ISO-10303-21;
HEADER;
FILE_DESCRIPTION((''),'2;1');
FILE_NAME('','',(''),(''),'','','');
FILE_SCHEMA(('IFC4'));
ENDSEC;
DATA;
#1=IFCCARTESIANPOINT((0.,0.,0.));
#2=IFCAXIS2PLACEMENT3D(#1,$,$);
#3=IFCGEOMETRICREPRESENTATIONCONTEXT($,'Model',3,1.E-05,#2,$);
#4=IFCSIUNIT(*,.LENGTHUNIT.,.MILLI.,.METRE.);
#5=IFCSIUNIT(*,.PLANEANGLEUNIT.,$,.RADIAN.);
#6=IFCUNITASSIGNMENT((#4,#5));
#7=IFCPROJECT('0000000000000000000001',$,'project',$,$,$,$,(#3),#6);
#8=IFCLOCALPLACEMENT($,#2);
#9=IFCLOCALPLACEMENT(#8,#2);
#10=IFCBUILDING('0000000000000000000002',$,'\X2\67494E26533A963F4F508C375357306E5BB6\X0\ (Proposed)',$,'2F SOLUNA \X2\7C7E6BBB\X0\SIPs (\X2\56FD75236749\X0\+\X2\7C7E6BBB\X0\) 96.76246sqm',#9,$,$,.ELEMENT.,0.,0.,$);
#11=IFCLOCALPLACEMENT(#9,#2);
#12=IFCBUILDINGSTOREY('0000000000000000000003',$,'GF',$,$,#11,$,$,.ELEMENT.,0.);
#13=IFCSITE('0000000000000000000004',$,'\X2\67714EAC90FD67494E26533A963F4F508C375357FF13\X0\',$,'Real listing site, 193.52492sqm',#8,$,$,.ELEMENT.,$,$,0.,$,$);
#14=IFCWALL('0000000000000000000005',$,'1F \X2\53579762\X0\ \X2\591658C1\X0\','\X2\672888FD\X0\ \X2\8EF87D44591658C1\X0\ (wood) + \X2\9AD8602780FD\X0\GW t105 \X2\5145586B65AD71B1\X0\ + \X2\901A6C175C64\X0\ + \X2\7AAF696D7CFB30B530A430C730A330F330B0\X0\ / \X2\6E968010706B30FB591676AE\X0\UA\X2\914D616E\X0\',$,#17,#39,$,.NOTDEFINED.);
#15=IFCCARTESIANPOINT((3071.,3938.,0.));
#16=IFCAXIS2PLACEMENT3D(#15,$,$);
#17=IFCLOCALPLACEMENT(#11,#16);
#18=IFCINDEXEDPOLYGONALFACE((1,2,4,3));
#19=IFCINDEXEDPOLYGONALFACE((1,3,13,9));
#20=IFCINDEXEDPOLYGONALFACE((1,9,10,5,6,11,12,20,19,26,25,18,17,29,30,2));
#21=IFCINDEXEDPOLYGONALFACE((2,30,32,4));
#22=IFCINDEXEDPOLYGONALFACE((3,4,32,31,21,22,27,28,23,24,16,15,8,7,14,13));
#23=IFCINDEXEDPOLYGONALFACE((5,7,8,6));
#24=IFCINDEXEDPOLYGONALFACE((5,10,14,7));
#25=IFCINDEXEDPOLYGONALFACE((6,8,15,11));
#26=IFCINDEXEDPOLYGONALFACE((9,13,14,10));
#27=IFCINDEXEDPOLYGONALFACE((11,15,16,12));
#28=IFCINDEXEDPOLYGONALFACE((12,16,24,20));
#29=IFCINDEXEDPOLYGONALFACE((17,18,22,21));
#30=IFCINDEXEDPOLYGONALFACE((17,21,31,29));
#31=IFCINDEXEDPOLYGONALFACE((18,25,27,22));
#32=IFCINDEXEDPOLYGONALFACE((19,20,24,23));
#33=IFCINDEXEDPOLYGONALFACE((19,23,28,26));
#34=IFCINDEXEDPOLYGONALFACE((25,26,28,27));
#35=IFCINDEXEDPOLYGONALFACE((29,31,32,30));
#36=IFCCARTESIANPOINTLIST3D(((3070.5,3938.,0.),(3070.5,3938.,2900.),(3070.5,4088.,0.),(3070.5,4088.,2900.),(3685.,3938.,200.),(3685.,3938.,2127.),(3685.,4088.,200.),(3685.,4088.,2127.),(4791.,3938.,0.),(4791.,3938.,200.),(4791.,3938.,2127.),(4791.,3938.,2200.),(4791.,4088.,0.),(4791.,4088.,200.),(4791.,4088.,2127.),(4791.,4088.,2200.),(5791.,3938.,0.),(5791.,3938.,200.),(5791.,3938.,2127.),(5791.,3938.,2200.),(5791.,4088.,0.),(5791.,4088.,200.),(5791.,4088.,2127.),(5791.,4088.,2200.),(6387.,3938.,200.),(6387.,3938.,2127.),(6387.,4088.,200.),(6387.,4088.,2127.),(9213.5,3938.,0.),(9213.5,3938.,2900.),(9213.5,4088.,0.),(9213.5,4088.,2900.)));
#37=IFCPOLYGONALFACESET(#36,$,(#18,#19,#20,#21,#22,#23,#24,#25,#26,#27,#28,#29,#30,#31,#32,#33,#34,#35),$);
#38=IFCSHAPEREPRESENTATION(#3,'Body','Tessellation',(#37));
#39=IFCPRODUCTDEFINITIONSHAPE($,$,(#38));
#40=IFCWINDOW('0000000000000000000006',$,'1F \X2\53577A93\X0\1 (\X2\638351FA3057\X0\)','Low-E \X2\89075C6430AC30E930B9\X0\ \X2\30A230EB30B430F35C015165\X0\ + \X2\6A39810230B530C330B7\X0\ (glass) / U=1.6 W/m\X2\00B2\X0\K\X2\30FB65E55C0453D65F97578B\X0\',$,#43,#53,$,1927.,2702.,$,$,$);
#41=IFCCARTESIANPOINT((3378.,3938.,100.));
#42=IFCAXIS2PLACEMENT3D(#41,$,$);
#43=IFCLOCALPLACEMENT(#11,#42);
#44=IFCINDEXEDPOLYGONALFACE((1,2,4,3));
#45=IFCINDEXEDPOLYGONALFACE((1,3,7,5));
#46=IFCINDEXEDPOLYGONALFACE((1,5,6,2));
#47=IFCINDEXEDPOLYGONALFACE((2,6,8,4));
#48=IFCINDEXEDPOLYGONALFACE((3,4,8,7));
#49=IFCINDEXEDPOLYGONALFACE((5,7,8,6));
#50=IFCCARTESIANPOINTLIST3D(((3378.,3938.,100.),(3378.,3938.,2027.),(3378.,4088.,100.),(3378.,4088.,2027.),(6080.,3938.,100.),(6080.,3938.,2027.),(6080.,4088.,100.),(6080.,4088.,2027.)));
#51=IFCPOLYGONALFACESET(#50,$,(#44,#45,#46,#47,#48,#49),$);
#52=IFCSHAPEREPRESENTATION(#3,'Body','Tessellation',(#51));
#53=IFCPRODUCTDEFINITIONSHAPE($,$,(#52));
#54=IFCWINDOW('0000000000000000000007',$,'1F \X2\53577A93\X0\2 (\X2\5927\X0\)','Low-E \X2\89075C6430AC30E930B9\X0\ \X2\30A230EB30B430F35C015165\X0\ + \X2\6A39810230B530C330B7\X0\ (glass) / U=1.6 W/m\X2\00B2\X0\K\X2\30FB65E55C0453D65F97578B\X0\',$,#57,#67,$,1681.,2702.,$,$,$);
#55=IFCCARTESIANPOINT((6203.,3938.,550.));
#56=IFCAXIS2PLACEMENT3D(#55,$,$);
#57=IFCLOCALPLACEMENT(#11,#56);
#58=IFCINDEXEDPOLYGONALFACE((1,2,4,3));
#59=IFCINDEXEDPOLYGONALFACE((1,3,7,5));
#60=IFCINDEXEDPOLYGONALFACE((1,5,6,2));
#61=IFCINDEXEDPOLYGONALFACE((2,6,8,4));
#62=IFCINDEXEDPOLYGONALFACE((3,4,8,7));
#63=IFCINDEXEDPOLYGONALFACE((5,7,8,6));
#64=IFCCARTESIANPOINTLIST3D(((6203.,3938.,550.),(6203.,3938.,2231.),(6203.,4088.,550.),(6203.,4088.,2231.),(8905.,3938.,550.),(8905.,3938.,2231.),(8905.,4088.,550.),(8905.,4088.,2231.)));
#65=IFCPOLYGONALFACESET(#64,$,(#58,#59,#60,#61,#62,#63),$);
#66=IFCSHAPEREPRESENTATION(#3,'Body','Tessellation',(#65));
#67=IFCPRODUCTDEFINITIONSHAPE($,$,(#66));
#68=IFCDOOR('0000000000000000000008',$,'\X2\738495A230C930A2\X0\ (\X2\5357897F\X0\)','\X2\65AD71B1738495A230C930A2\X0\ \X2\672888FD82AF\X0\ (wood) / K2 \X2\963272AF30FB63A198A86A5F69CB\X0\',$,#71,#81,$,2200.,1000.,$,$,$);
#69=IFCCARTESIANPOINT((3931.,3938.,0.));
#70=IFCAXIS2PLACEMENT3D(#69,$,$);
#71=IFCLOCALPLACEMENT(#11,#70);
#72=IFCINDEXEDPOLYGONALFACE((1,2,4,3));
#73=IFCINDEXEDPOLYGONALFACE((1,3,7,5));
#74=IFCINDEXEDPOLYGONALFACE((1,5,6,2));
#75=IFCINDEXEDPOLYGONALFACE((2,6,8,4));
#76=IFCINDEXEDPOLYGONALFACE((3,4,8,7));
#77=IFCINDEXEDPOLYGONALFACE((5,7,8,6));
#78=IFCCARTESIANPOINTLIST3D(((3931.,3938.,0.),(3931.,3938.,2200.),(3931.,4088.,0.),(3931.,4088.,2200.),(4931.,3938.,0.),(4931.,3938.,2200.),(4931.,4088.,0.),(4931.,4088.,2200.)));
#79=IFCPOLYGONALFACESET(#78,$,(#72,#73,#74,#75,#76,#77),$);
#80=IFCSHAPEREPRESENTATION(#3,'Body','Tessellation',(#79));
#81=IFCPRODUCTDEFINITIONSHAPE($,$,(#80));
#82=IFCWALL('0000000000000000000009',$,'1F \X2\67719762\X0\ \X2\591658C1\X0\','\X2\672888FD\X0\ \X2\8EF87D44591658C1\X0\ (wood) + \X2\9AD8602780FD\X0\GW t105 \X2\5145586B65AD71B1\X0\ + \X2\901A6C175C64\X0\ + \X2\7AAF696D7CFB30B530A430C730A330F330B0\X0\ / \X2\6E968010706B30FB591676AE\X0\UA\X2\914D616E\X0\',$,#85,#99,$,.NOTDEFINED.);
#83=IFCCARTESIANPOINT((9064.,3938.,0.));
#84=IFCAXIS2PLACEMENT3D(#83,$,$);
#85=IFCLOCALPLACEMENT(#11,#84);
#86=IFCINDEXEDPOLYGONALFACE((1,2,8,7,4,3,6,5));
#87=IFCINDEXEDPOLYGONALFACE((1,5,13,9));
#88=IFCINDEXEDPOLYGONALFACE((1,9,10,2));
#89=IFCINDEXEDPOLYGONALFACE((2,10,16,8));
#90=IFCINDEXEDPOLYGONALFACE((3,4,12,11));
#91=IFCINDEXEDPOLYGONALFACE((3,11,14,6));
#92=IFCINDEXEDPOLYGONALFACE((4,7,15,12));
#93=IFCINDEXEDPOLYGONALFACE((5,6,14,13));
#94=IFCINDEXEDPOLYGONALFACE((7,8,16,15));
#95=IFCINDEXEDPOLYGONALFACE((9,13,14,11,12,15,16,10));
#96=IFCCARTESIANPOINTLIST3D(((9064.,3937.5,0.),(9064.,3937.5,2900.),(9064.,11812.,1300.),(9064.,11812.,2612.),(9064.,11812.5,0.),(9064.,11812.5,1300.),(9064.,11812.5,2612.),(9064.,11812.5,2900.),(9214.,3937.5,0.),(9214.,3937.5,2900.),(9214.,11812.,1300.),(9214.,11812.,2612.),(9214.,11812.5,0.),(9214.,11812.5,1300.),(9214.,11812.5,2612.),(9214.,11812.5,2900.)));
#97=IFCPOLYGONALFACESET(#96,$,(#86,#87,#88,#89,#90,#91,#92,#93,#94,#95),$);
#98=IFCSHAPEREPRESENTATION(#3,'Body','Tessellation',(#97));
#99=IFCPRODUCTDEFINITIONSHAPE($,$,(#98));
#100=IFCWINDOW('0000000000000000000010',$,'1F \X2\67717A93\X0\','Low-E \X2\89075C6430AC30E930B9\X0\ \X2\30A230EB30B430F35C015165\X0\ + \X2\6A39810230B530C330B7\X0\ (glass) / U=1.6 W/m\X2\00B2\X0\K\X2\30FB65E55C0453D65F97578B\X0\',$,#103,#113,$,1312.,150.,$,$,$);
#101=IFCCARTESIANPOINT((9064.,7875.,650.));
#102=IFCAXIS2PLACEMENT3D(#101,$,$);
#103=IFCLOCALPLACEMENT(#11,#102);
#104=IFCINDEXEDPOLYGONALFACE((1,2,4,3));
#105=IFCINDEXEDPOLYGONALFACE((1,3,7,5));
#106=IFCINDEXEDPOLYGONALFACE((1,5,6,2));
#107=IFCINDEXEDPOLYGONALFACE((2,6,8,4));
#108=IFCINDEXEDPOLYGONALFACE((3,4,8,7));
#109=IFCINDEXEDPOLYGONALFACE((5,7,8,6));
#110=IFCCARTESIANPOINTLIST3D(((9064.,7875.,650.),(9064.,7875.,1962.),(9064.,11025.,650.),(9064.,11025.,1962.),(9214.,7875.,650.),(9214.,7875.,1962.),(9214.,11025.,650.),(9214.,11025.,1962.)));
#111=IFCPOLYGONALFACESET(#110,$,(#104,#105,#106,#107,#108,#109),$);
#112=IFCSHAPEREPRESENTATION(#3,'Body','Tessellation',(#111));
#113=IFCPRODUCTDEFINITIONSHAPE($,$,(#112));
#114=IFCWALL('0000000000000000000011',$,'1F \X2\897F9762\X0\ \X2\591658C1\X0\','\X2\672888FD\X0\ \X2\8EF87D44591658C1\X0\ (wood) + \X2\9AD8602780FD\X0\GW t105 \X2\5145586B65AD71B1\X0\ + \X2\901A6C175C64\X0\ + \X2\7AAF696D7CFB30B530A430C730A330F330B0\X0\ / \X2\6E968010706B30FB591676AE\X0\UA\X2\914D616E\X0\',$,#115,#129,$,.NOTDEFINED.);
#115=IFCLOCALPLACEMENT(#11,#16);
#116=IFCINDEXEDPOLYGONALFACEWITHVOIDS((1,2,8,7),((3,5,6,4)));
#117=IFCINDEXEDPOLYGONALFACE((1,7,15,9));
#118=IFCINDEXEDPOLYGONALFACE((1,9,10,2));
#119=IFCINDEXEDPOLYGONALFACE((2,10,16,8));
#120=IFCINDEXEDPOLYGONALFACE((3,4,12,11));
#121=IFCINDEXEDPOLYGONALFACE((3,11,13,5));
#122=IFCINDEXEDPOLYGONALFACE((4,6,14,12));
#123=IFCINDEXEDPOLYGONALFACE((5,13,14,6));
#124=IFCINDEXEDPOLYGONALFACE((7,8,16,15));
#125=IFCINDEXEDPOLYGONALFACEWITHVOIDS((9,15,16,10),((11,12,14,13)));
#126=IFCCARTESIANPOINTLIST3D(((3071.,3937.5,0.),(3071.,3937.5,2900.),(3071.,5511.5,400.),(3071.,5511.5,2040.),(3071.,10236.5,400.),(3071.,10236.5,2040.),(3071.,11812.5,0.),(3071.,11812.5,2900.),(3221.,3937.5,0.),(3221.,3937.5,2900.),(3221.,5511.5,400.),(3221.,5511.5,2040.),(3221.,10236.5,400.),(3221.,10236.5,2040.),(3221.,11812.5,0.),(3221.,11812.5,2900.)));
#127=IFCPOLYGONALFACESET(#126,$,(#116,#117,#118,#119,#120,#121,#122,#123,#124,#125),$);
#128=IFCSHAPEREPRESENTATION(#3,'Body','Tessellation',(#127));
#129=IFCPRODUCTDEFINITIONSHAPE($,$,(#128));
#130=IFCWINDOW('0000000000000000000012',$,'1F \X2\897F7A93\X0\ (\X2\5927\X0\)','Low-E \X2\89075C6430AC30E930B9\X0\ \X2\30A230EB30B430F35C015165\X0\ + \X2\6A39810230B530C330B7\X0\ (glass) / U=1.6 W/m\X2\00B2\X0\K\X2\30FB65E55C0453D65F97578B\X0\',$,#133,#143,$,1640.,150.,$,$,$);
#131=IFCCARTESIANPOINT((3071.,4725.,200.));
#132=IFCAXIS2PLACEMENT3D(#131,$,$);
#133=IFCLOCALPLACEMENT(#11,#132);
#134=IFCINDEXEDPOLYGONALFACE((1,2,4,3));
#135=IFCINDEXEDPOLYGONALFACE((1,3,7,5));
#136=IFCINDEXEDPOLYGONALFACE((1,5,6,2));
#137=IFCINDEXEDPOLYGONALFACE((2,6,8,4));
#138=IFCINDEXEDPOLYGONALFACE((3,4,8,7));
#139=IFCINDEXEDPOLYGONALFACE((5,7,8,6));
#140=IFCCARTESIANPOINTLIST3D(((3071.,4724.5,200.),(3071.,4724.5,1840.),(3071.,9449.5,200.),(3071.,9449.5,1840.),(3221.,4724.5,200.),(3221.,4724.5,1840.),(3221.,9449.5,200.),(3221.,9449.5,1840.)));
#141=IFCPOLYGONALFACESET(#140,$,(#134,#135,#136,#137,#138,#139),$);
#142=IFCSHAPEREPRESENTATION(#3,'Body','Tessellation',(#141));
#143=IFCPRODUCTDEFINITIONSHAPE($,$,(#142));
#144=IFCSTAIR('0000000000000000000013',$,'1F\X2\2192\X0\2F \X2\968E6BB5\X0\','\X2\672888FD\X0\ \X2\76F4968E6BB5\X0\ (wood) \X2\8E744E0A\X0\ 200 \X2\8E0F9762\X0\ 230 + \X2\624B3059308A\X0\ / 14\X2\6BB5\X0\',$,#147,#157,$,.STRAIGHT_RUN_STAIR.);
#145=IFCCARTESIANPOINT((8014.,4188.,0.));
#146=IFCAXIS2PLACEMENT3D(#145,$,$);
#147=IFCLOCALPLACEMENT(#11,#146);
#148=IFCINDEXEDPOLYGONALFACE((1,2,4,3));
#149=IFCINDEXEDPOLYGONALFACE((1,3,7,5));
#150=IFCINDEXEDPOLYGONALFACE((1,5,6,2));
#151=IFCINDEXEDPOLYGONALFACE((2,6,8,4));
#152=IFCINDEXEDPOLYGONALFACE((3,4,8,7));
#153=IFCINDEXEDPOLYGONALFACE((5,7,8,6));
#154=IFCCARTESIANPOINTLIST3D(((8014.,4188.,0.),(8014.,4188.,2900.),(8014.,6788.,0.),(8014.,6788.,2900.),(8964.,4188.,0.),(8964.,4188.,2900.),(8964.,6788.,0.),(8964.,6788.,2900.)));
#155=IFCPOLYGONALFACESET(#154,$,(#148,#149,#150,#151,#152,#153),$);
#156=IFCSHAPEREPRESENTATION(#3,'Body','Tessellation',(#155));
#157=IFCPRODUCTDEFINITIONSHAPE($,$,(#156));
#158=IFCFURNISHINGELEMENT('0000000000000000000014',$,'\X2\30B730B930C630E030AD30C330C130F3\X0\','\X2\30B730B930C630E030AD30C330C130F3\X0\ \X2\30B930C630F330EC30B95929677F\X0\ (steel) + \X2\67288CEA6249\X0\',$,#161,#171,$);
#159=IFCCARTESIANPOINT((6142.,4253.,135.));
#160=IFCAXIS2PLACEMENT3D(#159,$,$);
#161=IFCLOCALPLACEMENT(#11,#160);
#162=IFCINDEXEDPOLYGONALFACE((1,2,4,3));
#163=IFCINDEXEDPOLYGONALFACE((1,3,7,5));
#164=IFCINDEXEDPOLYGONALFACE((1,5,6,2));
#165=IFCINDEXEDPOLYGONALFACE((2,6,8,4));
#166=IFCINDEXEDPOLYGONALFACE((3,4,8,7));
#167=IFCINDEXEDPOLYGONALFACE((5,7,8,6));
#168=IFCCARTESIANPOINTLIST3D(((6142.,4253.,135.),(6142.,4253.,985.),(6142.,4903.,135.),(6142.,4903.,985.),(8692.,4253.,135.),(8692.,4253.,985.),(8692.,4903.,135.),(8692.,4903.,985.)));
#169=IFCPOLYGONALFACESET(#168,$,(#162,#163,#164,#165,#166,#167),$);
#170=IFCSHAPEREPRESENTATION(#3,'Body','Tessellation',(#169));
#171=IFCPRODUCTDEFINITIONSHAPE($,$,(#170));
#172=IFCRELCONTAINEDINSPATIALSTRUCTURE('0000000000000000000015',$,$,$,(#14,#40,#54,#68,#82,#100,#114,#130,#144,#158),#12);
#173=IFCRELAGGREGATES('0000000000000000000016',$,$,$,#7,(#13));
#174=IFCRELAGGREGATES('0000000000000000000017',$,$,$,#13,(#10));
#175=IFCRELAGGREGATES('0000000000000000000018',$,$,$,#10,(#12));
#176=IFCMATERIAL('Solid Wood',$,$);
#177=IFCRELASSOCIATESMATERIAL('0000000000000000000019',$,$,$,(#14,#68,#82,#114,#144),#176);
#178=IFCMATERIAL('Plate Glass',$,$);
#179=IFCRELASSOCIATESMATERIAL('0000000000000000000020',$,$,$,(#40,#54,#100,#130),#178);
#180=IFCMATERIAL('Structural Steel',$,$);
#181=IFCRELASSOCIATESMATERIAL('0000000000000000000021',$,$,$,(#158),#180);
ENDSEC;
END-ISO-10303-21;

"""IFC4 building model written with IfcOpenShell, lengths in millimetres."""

from ifc_helpers import new_model, si_unit, frame, frame_2d, origin, place, context, project, spatial, rectangle, extrude, material, element, fill, save


model = new_model("IFC4")

# Units and contexts
model_context = context("Model", 3, precision=1e-05, world=origin())
ifc_project = project(units=[si_unit("LENGTHUNIT", "METRE", prefix="MILLI"), si_unit("PLANEANGLEUNIT", "RADIAN")], contexts=[model_context])

# Site, building, storey
site_placement = place(None, origin())
site = spatial("IfcSite", under=ifc_project, at=site_placement, Name="東京都杉並区阿佐谷南３", ObjectType="Real listing site, 193.52492sqm", CompositionType="ELEMENT", RefElevation=0.0)
building_placement = place(site_placement, origin())
building = spatial("IfcBuilding", under=site, at=building_placement, Name="杉並区阿佐谷南の家 (Proposed)", ObjectType="2F SOLUNA 籾殻SIPs (国産杉+籾殻) 96.76246sqm", CompositionType="ELEMENT", ElevationOfRefHeight=0.0, ElevationOfTerrain=0.0)
storey_placement = place(building_placement, origin())
storey = spatial("IfcBuildingStorey", under=building, at=storey_placement, Name="GF", CompositionType="ELEMENT", Elevation=0.0)

# Shared definitions
ifc_material_1 = material(Name="Solid Wood")

# Wall, openings, windows, door
wall_1_placement = place(storey_placement, frame((3071.0, 3938.0, 0.0)))
wall_1 = element("IfcWall", 1, at=wall_1_placement, inside=storey, material=ifc_material_1, Name="1F 南面 外壁", Description="木製 軸組外壁 (wood) + 高性能GW t105 充填断熱 + 通気層 + 窯業系サイディング / 準耐火・外皮UA配慮", PredefinedType="NOTDEFINED", context=model_context, shape_type="SweptSolid", body=[
    extrude(rectangle(XDim=6143.0, YDim=150.0, at=frame_2d((3071.0, 75.0))), frame((3071.0, 3938.0, 0.0)), (0.0, 0.0, 1.0), 2900.0),
])
opening_1_placement = place(storey_placement, frame((3378.0, 3938.0, 100.0)))
opening_1 = element("IfcOpeningElement", 2, at=opening_1_placement, cuts=wall_1, PredefinedType="NOTDEFINED", context=model_context, shape_type="SweptSolid", body=[
    extrude(rectangle(XDim=2702.0, YDim=150.0, at=frame_2d((1351.0, 75.0))), frame((3378.0, 3938.0, 100.0)), (0.0, 0.0, 1.0), 1927.0),
])
opening_2_placement = place(storey_placement, frame((6203.0, 3938.0, 550.0)))
opening_2 = element("IfcOpeningElement", 3, at=opening_2_placement, cuts=wall_1, PredefinedType="NOTDEFINED", context=model_context, shape_type="SweptSolid", body=[
    extrude(rectangle(XDim=2702.0, YDim=150.0, at=frame_2d((1351.0, 75.0))), frame((6203.0, 3938.0, 550.0)), (0.0, 0.0, 1.0), 1681.0),
])
opening_3_placement = place(storey_placement, frame((3931.0, 3938.0, 0.0)))
opening_3 = element("IfcOpeningElement", 4, at=opening_3_placement, cuts=wall_1, PredefinedType="NOTDEFINED", context=model_context, shape_type="SweptSolid", body=[
    extrude(rectangle(XDim=1000.0, YDim=150.0, at=frame_2d((500.0, 75.0))), frame((3931.0, 3938.0, 0.0)), (0.0, 0.0, 1.0), 2200.0),
])
ifc_material_2 = material(Name="Plate Glass")
window_1_placement = place(storey_placement, frame((3378.0, 3938.0, 100.0)))
window_1 = element("IfcWindow", 5, at=window_1_placement, inside=storey, material=ifc_material_2, Name="1F 南窓1 (掃出し)", Description="Low-E 複層ガラス アルゴン封入 + 樹脂サッシ (glass) / U=1.6 W/m²K・日射取得型", OverallHeight=1927.0, OverallWidth=2702.0, context=model_context, shape_type="SweptSolid", body=[
    extrude(rectangle(XDim=2702.0, YDim=150.0, at=frame_2d((1351.0, 75.0))), frame((3378.0, 3938.0, 100.0)), (0.0, 0.0, 1.0), 1927.0),
])
fill(opening_1, window_1)
window_2_placement = place(storey_placement, frame((6203.0, 3938.0, 550.0)))
window_2 = element("IfcWindow", 6, at=window_2_placement, inside=storey, material=ifc_material_2, Name="1F 南窓2 (大)", Description="Low-E 複層ガラス アルゴン封入 + 樹脂サッシ (glass) / U=1.6 W/m²K・日射取得型", OverallHeight=1681.0, OverallWidth=2702.0, context=model_context, shape_type="SweptSolid", body=[
    extrude(rectangle(XDim=2702.0, YDim=150.0, at=frame_2d((1351.0, 75.0))), frame((6203.0, 3938.0, 550.0)), (0.0, 0.0, 1.0), 1681.0),
])
fill(opening_2, window_2)
door_placement = place(storey_placement, frame((3931.0, 3938.0, 0.0)))
door = element("IfcDoor", 7, at=door_placement, inside=storey, material=ifc_material_1, Name="玄関ドア (南西)", Description="断熱玄関ドア 木製芯 (wood) / K2 防犯・採風機構", OverallHeight=2200.0, OverallWidth=1000.0, context=model_context, shape_type="SweptSolid", body=[
    extrude(rectangle(XDim=1000.0, YDim=150.0, at=frame_2d((500.0, 75.0))), frame((3931.0, 3938.0, 0.0)), (0.0, 0.0, 1.0), 2200.0),
])
fill(opening_3, door)

# Walls, openings, windows
wall_2_placement = place(storey_placement, frame((9064.0, 3938.0, 0.0)))
wall_2 = element("IfcWall", 8, at=wall_2_placement, inside=storey, material=ifc_material_1, Name="1F 東面 外壁", Description="木製 軸組外壁 (wood) + 高性能GW t105 充填断熱 + 通気層 + 窯業系サイディング / 準耐火・外皮UA配慮", PredefinedType="NOTDEFINED", context=model_context, shape_type="SweptSolid", body=[
    extrude(rectangle(XDim=150.0, YDim=7875.0, at=frame_2d((75.0, 3937.0))), frame((9064.0, 3938.0, 0.0)), (0.0, 0.0, 1.0), 2900.0),
])
opening_4_placement = place(storey_placement, frame((9064.0, 7875.0, 650.0)))
opening_4 = element("IfcOpeningElement", 9, at=opening_4_placement, cuts=wall_2, PredefinedType="NOTDEFINED", context=model_context, shape_type="SweptSolid", body=[
    extrude(rectangle(XDim=150.0, YDim=3150.0, at=frame_2d((75.0, 1575.0))), frame((9064.0, 7875.0, 650.0)), (0.0, 0.0, 1.0), 1312.0),
])
window_3_placement = place(storey_placement, frame((9064.0, 7875.0, 650.0)))
window_3 = element("IfcWindow", 10, at=window_3_placement, inside=storey, material=ifc_material_2, Name="1F 東窓", Description="Low-E 複層ガラス アルゴン封入 + 樹脂サッシ (glass) / U=1.6 W/m²K・日射取得型", OverallHeight=1312.0, OverallWidth=150.0, context=model_context, shape_type="SweptSolid", body=[
    extrude(rectangle(XDim=150.0, YDim=3150.0, at=frame_2d((75.0, 1575.0))), frame((9064.0, 7875.0, 650.0)), (0.0, 0.0, 1.0), 1312.0),
])
fill(opening_4, window_3)
wall_3_placement = place(storey_placement, frame((3071.0, 3938.0, 0.0)))
wall_3 = element("IfcWall", 11, at=wall_3_placement, inside=storey, material=ifc_material_1, Name="1F 西面 外壁", Description="木製 軸組外壁 (wood) + 高性能GW t105 充填断熱 + 通気層 + 窯業系サイディング / 準耐火・外皮UA配慮", PredefinedType="NOTDEFINED", context=model_context, shape_type="SweptSolid", body=[
    extrude(rectangle(XDim=150.0, YDim=7875.0, at=frame_2d((75.0, 3937.0))), frame((3071.0, 3938.0, 0.0)), (0.0, 0.0, 1.0), 2900.0),
])
opening_5_placement = place(storey_placement, frame((3071.0, 4725.0, 200.0)))
opening_5 = element("IfcOpeningElement", 12, at=opening_5_placement, cuts=wall_3, PredefinedType="NOTDEFINED", context=model_context, shape_type="SweptSolid", body=[
    extrude(rectangle(XDim=150.0, YDim=4725.0, at=frame_2d((75.0, 2362.0))), frame((3071.0, 4725.0, 200.0)), (0.0, 0.0, 1.0), 1640.0),
])
window_4_placement = place(storey_placement, frame((3071.0, 4725.0, 200.0)))
window_4 = element("IfcWindow", 13, at=window_4_placement, inside=storey, material=ifc_material_2, Name="1F 西窓 (大)", Description="Low-E 複層ガラス アルゴン封入 + 樹脂サッシ (glass) / U=1.6 W/m²K・日射取得型", OverallHeight=1640.0, OverallWidth=150.0, context=model_context, shape_type="SweptSolid", body=[
    extrude(rectangle(XDim=150.0, YDim=4725.0, at=frame_2d((75.0, 2362.0))), frame((3071.0, 4725.0, 200.0)), (0.0, 0.0, 1.0), 1640.0),
])
fill(opening_5, window_4)

# Stair
stair_placement = place(storey_placement, frame((8014.0, 4188.0, 0.0)))
element("IfcStair", 14, at=stair_placement, inside=storey, material=ifc_material_1, Name="1F→2F 階段", Description="木製 直階段 (wood) 蹴上 200 踏面 230 + 手すり / 14段", PredefinedType="STRAIGHT_RUN_STAIR", context=model_context, shape_type="SweptSolid", body=[
    extrude(rectangle(XDim=950.0, YDim=2600.0, at=frame_2d((475.0, 1300.0))), frame((8014.0, 4188.0, 0.0)), (0.0, 0.0, 1.0), 2900.0),
])

# Furnishing element
ifc_material_3 = material(Name="Structural Steel")
furnishing_placement = place(storey_placement, frame((6142.0, 4253.0, 135.0)))
element("IfcFurnishingElement", 15, at=furnishing_placement, inside=storey, material=ifc_material_3, Name="システムキッチン", Description="システムキッチン ステンレス天板 (steel) + 木質扉", context=model_context, shape_type="SweptSolid", body=[
    extrude(rectangle(XDim=2550.0, YDim=650.0, at=frame_2d((1275.0, 325.0))), frame((6142.0, 4253.0, 135.0)), (0.0, 0.0, 1.0), 850.0),
])

save(model, "model.ifc")
